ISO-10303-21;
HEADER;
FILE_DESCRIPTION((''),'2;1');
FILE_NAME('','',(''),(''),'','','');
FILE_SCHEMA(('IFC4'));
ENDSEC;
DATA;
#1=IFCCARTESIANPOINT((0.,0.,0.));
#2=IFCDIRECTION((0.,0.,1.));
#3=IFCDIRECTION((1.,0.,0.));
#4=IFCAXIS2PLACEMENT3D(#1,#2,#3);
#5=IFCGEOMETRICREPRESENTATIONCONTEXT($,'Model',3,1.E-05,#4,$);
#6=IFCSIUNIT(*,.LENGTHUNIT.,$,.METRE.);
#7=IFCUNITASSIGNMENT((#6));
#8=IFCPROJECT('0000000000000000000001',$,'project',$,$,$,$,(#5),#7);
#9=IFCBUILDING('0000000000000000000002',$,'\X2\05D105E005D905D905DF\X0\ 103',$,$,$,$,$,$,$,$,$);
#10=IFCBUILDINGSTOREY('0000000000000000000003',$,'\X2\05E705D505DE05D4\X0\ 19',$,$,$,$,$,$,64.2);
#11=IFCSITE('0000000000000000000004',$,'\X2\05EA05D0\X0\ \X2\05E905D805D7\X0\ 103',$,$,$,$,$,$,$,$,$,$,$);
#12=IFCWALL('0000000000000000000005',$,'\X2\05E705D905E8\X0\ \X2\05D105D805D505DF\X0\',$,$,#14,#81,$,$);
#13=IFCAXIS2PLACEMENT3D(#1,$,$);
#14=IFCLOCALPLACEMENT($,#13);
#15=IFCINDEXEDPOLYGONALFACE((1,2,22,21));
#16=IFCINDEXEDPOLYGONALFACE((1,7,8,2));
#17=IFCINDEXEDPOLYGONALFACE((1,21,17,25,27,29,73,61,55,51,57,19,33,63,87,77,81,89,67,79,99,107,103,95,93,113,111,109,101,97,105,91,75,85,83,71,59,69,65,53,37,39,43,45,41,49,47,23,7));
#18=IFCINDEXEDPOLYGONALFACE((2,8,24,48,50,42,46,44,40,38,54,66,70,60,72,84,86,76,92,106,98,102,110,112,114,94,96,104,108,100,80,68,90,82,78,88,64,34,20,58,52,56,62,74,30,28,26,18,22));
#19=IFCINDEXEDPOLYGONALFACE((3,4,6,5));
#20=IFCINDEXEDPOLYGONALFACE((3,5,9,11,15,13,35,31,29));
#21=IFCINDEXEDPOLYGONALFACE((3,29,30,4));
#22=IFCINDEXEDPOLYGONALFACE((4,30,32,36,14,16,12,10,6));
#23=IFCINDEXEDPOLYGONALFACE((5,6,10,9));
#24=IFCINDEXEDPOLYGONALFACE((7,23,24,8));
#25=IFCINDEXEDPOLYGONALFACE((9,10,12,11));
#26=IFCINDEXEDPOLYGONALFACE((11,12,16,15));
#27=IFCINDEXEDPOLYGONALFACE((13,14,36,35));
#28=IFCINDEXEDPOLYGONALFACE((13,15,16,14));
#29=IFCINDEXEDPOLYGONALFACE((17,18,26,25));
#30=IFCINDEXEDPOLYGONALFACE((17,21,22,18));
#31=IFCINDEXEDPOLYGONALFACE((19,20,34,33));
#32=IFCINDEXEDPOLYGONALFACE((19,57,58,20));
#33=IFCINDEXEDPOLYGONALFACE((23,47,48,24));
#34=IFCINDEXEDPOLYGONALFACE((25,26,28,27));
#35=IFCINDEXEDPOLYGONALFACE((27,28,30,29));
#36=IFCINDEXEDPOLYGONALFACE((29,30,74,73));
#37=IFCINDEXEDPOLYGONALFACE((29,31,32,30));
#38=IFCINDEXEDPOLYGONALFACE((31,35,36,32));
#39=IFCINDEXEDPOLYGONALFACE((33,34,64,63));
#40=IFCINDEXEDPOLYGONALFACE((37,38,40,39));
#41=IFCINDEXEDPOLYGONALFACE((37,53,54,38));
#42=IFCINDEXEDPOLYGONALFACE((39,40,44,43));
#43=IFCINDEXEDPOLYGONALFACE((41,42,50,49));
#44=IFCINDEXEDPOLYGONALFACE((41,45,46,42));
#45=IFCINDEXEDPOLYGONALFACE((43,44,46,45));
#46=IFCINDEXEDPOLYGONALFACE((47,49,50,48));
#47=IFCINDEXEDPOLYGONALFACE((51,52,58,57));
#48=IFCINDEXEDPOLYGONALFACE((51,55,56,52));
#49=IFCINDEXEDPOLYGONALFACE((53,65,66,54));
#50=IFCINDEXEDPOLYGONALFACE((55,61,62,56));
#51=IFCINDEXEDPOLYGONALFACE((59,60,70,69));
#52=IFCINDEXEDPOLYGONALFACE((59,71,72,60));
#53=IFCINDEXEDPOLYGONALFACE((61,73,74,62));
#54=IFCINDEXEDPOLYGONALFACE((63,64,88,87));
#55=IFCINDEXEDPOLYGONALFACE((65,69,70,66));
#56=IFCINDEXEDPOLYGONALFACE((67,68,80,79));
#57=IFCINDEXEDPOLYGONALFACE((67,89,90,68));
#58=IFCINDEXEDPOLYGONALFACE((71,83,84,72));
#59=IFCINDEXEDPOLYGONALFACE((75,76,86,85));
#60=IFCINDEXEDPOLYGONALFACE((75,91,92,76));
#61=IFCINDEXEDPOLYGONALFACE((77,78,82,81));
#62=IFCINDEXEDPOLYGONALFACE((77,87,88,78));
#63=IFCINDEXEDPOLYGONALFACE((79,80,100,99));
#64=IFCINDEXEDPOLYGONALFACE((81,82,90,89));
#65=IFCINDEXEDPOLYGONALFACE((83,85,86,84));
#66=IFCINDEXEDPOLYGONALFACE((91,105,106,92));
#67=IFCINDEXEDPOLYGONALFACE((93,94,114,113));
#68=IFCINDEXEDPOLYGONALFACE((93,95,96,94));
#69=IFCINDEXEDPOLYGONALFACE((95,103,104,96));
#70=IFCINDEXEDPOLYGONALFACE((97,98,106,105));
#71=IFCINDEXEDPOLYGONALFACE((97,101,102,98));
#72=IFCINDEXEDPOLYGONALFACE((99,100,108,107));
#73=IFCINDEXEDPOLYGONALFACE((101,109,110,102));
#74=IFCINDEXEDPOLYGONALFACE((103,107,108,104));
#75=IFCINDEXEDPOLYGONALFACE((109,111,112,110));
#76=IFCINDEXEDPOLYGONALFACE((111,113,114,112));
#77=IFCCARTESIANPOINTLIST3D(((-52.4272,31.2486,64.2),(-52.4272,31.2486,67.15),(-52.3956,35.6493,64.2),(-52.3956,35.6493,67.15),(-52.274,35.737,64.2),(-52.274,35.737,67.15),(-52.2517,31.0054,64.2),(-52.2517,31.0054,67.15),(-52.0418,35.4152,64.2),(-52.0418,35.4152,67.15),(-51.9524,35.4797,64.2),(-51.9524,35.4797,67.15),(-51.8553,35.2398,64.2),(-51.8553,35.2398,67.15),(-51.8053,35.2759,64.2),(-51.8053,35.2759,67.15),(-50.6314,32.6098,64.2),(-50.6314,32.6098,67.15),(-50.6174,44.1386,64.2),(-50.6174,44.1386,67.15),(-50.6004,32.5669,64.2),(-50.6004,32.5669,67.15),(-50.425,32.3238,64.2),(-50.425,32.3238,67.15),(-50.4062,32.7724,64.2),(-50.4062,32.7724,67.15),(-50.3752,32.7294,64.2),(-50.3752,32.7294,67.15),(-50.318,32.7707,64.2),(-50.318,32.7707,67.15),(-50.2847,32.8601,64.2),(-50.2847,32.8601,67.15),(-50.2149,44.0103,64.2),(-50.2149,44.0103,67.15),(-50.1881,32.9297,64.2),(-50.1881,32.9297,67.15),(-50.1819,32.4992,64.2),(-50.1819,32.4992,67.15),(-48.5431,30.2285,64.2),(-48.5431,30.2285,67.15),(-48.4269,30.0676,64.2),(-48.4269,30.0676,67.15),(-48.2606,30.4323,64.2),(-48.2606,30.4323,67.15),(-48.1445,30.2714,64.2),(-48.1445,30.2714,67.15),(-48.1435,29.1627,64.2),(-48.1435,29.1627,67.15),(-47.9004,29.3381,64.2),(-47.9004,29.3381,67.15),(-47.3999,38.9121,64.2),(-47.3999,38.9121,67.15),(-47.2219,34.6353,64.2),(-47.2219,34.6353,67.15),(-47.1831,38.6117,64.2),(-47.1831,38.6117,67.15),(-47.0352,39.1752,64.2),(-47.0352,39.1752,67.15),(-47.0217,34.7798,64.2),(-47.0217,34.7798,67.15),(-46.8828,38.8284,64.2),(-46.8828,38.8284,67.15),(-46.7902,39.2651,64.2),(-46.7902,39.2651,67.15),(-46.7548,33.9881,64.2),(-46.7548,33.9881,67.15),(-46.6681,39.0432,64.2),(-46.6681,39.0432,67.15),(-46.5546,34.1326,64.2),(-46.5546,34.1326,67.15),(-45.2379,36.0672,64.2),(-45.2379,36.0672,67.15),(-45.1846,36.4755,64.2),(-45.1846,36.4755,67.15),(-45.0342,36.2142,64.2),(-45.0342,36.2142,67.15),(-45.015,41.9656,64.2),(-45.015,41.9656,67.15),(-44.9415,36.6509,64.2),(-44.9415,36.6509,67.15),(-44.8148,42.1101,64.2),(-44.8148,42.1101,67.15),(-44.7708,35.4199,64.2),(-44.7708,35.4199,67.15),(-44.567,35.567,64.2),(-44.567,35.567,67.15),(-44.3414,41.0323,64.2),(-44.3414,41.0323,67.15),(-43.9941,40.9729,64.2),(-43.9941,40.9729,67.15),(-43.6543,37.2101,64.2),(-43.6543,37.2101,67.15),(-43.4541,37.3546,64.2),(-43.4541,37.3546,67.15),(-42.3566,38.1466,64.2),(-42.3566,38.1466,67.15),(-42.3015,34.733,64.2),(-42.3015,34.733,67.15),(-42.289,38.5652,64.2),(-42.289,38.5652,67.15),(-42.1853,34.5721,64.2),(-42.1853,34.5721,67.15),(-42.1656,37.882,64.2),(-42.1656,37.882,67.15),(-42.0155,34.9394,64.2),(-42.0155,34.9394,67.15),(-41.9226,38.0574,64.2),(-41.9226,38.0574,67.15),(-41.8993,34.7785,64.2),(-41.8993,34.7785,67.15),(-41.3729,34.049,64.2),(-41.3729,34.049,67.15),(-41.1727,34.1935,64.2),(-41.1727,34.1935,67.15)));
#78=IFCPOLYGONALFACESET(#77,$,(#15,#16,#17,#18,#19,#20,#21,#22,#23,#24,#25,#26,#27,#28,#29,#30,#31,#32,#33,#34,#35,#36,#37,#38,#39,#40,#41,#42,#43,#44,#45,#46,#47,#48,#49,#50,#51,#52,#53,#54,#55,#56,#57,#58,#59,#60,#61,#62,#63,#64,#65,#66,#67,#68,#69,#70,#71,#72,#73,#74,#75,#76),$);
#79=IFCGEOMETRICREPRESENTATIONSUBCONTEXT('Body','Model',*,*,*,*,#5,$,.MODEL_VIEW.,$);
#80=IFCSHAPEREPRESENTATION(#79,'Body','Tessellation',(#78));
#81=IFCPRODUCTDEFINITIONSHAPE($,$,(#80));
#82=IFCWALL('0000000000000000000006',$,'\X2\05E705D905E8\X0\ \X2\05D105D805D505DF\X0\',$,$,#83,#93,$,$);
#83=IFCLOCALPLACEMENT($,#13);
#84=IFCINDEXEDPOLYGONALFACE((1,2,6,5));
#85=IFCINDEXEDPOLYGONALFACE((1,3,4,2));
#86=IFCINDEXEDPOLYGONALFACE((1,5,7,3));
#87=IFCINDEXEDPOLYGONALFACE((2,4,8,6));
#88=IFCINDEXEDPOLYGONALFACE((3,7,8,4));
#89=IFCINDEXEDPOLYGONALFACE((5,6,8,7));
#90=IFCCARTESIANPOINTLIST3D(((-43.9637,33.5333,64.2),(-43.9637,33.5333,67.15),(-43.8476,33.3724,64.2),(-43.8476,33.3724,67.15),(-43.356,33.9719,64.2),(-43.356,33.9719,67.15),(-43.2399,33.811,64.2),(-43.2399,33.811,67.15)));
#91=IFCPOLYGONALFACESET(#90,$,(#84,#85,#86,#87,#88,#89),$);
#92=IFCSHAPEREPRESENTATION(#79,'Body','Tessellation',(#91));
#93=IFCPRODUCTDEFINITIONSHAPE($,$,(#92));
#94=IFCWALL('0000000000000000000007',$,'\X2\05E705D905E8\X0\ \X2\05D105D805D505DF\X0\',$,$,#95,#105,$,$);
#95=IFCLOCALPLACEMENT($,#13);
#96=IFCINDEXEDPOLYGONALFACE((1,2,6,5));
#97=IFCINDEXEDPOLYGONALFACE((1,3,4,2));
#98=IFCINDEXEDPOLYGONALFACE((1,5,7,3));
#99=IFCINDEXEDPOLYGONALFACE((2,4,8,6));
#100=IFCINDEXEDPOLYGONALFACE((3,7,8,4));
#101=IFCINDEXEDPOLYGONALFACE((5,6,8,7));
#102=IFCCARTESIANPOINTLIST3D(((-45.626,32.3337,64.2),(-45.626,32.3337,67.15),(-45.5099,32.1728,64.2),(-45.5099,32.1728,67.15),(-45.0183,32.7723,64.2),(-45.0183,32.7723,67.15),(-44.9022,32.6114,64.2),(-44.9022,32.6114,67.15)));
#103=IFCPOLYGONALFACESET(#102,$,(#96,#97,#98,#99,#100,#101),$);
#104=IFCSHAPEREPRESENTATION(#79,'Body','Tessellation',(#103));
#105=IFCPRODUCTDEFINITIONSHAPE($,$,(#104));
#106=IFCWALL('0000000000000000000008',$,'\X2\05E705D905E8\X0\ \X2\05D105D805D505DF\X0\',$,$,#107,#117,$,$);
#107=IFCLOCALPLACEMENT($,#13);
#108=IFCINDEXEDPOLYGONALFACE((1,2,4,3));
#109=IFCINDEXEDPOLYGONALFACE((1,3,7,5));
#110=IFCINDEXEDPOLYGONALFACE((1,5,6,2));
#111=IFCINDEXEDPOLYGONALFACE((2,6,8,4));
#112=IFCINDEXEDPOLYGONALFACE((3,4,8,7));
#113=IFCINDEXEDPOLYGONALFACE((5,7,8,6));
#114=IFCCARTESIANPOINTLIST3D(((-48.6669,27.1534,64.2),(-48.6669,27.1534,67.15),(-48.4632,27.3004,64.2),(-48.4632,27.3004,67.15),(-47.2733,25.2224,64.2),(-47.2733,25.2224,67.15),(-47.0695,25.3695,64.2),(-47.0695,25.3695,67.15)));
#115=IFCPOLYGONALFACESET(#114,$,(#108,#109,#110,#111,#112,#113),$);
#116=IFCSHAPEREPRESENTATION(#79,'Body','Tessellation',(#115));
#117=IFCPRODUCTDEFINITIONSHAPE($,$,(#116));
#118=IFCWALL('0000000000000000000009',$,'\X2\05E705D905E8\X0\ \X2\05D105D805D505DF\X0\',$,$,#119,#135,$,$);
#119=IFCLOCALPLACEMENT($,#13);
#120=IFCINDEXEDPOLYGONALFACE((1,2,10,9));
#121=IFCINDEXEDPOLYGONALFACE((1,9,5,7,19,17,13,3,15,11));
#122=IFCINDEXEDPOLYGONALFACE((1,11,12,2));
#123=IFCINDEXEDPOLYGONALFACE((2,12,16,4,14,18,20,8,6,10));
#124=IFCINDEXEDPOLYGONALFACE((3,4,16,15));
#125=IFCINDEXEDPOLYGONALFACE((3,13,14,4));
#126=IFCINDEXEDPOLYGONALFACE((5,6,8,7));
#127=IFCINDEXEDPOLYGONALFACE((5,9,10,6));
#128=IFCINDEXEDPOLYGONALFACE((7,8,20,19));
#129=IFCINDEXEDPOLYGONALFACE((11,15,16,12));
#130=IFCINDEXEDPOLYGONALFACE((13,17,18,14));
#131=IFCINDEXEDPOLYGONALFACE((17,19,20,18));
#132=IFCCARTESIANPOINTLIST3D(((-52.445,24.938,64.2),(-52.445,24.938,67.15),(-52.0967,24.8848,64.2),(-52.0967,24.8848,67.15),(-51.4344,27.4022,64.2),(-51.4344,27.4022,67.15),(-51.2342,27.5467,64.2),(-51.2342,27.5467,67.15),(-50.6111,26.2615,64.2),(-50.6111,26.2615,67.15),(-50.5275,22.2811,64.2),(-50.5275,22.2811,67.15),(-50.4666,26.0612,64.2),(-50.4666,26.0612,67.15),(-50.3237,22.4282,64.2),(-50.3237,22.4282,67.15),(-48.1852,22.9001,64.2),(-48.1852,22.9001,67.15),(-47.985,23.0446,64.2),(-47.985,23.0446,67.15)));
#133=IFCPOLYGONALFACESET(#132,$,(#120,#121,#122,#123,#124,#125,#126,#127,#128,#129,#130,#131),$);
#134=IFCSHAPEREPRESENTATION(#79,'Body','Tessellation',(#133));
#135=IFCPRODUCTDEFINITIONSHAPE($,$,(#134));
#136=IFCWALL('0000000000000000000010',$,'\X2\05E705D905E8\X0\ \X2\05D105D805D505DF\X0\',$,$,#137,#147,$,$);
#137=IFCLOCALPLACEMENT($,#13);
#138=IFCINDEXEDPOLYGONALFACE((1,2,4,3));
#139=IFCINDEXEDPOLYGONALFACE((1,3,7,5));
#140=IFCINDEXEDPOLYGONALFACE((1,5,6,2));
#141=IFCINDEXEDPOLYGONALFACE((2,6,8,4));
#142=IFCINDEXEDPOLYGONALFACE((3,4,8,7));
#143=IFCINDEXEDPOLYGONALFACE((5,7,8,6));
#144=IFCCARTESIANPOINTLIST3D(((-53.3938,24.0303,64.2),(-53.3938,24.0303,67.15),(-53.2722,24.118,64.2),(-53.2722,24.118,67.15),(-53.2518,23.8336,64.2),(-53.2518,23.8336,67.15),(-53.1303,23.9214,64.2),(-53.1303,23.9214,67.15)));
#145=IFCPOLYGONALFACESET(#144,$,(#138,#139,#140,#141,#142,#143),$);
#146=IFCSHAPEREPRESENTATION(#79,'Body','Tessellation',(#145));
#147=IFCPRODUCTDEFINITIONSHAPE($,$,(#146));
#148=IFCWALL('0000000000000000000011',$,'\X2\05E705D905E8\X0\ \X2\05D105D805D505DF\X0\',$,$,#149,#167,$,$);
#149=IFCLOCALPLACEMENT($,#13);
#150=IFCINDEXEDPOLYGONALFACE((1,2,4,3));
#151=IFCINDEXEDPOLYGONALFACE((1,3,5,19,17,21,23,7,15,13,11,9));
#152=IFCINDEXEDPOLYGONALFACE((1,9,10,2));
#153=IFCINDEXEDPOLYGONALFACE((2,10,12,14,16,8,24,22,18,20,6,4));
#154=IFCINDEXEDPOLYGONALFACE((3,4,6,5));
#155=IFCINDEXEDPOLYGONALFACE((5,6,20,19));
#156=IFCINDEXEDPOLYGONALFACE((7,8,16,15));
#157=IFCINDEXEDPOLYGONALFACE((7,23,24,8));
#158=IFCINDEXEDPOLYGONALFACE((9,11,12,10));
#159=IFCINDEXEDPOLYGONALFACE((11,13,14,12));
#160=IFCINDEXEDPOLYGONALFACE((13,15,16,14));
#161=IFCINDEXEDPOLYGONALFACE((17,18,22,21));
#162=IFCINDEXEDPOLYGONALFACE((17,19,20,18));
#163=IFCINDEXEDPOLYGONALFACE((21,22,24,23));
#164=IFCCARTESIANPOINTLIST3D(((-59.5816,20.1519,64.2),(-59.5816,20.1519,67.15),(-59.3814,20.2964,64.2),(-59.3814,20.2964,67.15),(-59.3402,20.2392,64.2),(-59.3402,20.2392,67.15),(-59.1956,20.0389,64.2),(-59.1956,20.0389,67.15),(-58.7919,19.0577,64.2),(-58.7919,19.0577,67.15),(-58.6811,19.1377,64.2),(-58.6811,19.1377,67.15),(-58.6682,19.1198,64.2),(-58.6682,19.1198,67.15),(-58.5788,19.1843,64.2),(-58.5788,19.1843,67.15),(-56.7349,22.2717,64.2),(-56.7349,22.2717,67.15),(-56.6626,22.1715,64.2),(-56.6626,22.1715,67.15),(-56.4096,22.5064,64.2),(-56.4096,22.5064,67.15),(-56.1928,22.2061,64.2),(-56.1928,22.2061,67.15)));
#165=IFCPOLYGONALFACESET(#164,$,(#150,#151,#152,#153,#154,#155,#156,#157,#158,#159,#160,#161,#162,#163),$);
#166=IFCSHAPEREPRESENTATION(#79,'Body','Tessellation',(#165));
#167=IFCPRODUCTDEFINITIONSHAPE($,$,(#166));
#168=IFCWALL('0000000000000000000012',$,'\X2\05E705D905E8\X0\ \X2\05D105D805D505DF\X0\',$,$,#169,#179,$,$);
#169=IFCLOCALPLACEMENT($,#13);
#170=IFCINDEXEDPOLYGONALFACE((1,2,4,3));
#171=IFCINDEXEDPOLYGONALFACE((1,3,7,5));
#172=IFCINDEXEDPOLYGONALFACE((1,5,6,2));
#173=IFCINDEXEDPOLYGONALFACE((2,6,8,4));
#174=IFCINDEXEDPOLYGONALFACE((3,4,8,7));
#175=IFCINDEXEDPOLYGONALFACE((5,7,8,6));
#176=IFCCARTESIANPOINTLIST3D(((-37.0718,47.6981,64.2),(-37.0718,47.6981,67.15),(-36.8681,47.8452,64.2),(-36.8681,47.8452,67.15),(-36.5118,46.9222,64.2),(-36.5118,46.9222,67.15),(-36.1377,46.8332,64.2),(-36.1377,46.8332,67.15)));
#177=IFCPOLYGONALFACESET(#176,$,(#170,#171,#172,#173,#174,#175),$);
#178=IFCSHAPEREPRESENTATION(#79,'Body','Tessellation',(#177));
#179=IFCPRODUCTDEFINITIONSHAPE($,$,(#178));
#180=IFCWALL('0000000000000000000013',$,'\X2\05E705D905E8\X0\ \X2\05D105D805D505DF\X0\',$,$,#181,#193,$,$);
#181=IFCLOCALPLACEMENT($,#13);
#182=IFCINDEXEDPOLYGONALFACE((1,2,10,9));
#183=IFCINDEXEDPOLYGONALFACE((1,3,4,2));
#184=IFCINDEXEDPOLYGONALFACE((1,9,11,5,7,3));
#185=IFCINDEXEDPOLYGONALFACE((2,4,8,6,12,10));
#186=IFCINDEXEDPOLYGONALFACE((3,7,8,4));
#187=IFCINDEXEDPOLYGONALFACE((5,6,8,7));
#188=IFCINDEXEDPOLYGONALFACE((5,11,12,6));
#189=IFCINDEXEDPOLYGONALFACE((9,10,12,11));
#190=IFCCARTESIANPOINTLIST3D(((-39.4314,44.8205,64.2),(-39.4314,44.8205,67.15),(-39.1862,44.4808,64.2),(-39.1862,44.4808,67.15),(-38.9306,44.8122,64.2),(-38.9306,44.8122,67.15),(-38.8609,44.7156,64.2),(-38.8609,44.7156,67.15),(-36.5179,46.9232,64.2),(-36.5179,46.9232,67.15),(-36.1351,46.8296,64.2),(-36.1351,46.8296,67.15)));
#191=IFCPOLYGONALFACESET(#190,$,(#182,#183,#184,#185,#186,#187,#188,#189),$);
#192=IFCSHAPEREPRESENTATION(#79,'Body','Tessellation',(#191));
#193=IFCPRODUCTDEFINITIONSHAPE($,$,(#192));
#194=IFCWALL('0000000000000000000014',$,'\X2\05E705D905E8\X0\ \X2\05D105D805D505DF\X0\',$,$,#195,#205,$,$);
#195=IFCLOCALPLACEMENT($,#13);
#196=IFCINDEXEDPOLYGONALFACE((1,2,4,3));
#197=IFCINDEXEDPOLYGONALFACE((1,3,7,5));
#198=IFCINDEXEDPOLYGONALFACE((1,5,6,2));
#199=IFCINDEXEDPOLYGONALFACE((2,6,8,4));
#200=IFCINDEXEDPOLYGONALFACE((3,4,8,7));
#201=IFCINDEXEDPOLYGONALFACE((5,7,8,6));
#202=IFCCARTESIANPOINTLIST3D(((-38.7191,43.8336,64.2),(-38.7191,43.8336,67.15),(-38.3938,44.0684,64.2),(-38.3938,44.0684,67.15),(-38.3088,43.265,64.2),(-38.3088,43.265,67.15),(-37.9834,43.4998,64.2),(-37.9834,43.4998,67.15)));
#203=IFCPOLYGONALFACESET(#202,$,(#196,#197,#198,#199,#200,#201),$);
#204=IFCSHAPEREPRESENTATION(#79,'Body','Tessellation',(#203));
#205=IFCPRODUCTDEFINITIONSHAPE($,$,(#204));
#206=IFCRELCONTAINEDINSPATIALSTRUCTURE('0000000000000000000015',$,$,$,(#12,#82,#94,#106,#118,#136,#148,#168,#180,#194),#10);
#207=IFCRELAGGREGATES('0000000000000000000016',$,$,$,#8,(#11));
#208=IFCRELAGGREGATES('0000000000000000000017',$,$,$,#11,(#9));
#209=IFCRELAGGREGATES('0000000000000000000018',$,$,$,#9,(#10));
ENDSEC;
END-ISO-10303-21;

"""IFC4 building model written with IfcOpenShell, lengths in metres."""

from ifc_helpers import new_model, si_unit, frame, origin_with_axes, context, subcontext, project, spatial, polyline, outline, extrude, element, save


model = new_model("IFC4")

# Units and contexts
model_context = context("Model", 3, precision=1e-05, world=origin_with_axes())
body_context = subcontext(model_context, "Body", "Model", "MODEL_VIEW")
ifc_project = project(units=[si_unit("LENGTHUNIT", "METRE")], contexts=[model_context])

# Site, building, storey
site = spatial("IfcSite", under=ifc_project, Name="תא שטח 103")
building = spatial("IfcBuilding", under=site, Name="בניין 103")
storey = spatial("IfcBuildingStorey", under=building, Name="קומה 19", Elevation=64.2)

# Walls
element("IfcWall", 1, inside=storey, Name="קיר בטון", context=body_context, shape_type="SweptSolid", body=[
    extrude(outline(polyline([(-42.3015, 34.733), (-42.0155, 34.9394), (-43.6543, 37.2101), (-45.0342, 36.2142), (-44.567, 35.567), (-44.7708, 35.4199), (-45.2379, 36.0672), (-47.0217, 34.7798), (-46.5546, 34.1326), (-46.7548, 33.9881), (-47.2219, 34.6353), (-50.1819, 32.4992), (-48.5431, 30.2285), (-48.2606, 30.4323), (-48.1445, 30.2714), (-48.4269, 30.0676), (-47.9004, 29.3381), (-48.1435, 29.1627), (-50.425, 32.3238), (-52.2517, 31.0054), (-52.4272, 31.2486), (-50.6004, 32.5669), (-50.6314, 32.6098), (-50.4062, 32.7724), (-50.3752, 32.7294), (-50.318, 32.7707), (-52.3956, 35.6493), (-52.274, 35.737), (-52.0418, 35.4152), (-51.9524, 35.4797), (-51.8053, 35.2759), (-51.8553, 35.2398), (-50.1881, 32.9297), (-50.2847, 32.8601), (-50.318, 32.7707), (-45.1846, 36.4755), (-46.8828, 38.8284), (-47.1831, 38.6117), (-47.3999, 38.9121), (-47.0352, 39.1752), (-50.6174, 44.1386), (-50.2149, 44.0103), (-46.7902, 39.2651), (-44.3414, 41.0323), (-45.015, 41.9656), (-44.8148, 42.1101), (-43.9941, 40.9729), (-46.6681, 39.0432), (-44.9415, 36.6509), (-42.289, 38.5652), (-41.9226, 38.0574), (-42.1656, 37.882), (-42.3566, 38.1466), (-43.4541, 37.3546), (-41.1727, 34.1935), (-41.3729, 34.049), (-41.8993, 34.7785), (-42.1853, 34.5721), (-42.3015, 34.733)])), frame((0.0, 0.0, 64.2)), (0.0, 0.0, 1.0), 2.95),
])
element("IfcWall", 2, inside=storey, Name="קיר בטון", context=body_context, shape_type="SweptSolid", body=[
    extrude(outline(polyline([(-43.356, 33.9719), (-43.2399, 33.811), (-43.8476, 33.3724), (-43.9637, 33.5333), (-43.356, 33.9719)])), frame((0.0, 0.0, 64.2)), (0.0, 0.0, 1.0), 2.95),
])
element("IfcWall", 3, inside=storey, Name="קיר בטון", context=body_context, shape_type="SweptSolid", body=[
    extrude(outline(polyline([(-45.626, 32.3337), (-45.0183, 32.7723), (-44.9022, 32.6114), (-45.5099, 32.1728), (-45.626, 32.3337)])), frame((0.0, 0.0, 64.2)), (0.0, 0.0, 1.0), 2.95),
])
element("IfcWall", 4, inside=storey, Name="קיר בטון", context=body_context, shape_type="SweptSolid", body=[
    extrude(outline(polyline([(-48.4632, 27.3004), (-47.0695, 25.3695), (-47.2733, 25.2224), (-48.6669, 27.1534), (-48.4632, 27.3004)])), frame((0.0, 0.0, 64.2)), (0.0, 0.0, 1.0), 2.95),
])
element("IfcWall", 5, inside=storey, Name="קיר בטון", context=body_context, shape_type="SweptSolid", body=[
    extrude(outline(polyline([(-50.4666, 26.0612), (-52.0967, 24.8848), (-50.3237, 22.4282), (-50.5275, 22.2811), (-52.445, 24.938), (-50.6111, 26.2615), (-51.4344, 27.4022), (-51.2342, 27.5467), (-47.985, 23.0446), (-48.1852, 22.9001), (-50.4666, 26.0612)])), frame((0.0, 0.0, 64.2)), (0.0, 0.0, 1.0), 2.95),
])
element("IfcWall", 6, inside=storey, Name="קיר בטון", context=body_context, shape_type="SweptSolid", body=[
    extrude(outline(polyline([(-53.3938, 24.0303), (-53.2722, 24.118), (-53.1303, 23.9214), (-53.2518, 23.8336), (-53.3938, 24.0303)])), frame((0.0, 0.0, 64.2)), (0.0, 0.0, 1.0), 2.95),
])
element("IfcWall", 7, inside=storey, Name="קיר בטון", context=body_context, shape_type="SweptSolid", body=[
    extrude(outline(polyline([(-58.6682, 19.1198), (-58.6811, 19.1377), (-58.7919, 19.0577), (-59.5816, 20.1519), (-59.3814, 20.2964), (-59.3402, 20.2392), (-56.6626, 22.1715), (-56.7349, 22.2717), (-56.4096, 22.5064), (-56.1928, 22.2061), (-59.1956, 20.0389), (-58.5788, 19.1843), (-58.6682, 19.1198)])), frame((0.0, 0.0, 64.2)), (0.0, 0.0, 1.0), 2.95),
])
element("IfcWall", 8, inside=storey, Name="קיר בטון", context=body_context, shape_type="SweptSolid", body=[
    extrude(outline(polyline([(-36.5118, 46.9222), (-37.0718, 47.6981), (-36.8681, 47.8452), (-36.1377, 46.8332), (-36.5118, 46.9222)])), frame((0.0, 0.0, 64.2)), (0.0, 0.0, 1.0), 2.95),
])
element("IfcWall", 9, inside=storey, Name="קיר בטון", context=body_context, shape_type="SweptSolid", body=[
    extrude(outline(polyline([(-38.8609, 44.7156), (-39.1862, 44.4808), (-39.4314, 44.8205), (-36.5179, 46.9232), (-36.1351, 46.8296), (-38.9306, 44.8122), (-38.8609, 44.7156)])), frame((0.0, 0.0, 64.2)), (0.0, 0.0, 1.0), 2.95),
])
element("IfcWall", 10, inside=storey, Name="קיר בטון", context=body_context, shape_type="SweptSolid", body=[
    extrude(outline(polyline([(-37.9834, 43.4998), (-38.3088, 43.265), (-38.7191, 43.8336), (-38.3938, 44.0684), (-37.9834, 43.4998)])), frame((0.0, 0.0, 64.2)), (0.0, 0.0, 1.0), 2.95),
])

save(model, "model.ifc")
